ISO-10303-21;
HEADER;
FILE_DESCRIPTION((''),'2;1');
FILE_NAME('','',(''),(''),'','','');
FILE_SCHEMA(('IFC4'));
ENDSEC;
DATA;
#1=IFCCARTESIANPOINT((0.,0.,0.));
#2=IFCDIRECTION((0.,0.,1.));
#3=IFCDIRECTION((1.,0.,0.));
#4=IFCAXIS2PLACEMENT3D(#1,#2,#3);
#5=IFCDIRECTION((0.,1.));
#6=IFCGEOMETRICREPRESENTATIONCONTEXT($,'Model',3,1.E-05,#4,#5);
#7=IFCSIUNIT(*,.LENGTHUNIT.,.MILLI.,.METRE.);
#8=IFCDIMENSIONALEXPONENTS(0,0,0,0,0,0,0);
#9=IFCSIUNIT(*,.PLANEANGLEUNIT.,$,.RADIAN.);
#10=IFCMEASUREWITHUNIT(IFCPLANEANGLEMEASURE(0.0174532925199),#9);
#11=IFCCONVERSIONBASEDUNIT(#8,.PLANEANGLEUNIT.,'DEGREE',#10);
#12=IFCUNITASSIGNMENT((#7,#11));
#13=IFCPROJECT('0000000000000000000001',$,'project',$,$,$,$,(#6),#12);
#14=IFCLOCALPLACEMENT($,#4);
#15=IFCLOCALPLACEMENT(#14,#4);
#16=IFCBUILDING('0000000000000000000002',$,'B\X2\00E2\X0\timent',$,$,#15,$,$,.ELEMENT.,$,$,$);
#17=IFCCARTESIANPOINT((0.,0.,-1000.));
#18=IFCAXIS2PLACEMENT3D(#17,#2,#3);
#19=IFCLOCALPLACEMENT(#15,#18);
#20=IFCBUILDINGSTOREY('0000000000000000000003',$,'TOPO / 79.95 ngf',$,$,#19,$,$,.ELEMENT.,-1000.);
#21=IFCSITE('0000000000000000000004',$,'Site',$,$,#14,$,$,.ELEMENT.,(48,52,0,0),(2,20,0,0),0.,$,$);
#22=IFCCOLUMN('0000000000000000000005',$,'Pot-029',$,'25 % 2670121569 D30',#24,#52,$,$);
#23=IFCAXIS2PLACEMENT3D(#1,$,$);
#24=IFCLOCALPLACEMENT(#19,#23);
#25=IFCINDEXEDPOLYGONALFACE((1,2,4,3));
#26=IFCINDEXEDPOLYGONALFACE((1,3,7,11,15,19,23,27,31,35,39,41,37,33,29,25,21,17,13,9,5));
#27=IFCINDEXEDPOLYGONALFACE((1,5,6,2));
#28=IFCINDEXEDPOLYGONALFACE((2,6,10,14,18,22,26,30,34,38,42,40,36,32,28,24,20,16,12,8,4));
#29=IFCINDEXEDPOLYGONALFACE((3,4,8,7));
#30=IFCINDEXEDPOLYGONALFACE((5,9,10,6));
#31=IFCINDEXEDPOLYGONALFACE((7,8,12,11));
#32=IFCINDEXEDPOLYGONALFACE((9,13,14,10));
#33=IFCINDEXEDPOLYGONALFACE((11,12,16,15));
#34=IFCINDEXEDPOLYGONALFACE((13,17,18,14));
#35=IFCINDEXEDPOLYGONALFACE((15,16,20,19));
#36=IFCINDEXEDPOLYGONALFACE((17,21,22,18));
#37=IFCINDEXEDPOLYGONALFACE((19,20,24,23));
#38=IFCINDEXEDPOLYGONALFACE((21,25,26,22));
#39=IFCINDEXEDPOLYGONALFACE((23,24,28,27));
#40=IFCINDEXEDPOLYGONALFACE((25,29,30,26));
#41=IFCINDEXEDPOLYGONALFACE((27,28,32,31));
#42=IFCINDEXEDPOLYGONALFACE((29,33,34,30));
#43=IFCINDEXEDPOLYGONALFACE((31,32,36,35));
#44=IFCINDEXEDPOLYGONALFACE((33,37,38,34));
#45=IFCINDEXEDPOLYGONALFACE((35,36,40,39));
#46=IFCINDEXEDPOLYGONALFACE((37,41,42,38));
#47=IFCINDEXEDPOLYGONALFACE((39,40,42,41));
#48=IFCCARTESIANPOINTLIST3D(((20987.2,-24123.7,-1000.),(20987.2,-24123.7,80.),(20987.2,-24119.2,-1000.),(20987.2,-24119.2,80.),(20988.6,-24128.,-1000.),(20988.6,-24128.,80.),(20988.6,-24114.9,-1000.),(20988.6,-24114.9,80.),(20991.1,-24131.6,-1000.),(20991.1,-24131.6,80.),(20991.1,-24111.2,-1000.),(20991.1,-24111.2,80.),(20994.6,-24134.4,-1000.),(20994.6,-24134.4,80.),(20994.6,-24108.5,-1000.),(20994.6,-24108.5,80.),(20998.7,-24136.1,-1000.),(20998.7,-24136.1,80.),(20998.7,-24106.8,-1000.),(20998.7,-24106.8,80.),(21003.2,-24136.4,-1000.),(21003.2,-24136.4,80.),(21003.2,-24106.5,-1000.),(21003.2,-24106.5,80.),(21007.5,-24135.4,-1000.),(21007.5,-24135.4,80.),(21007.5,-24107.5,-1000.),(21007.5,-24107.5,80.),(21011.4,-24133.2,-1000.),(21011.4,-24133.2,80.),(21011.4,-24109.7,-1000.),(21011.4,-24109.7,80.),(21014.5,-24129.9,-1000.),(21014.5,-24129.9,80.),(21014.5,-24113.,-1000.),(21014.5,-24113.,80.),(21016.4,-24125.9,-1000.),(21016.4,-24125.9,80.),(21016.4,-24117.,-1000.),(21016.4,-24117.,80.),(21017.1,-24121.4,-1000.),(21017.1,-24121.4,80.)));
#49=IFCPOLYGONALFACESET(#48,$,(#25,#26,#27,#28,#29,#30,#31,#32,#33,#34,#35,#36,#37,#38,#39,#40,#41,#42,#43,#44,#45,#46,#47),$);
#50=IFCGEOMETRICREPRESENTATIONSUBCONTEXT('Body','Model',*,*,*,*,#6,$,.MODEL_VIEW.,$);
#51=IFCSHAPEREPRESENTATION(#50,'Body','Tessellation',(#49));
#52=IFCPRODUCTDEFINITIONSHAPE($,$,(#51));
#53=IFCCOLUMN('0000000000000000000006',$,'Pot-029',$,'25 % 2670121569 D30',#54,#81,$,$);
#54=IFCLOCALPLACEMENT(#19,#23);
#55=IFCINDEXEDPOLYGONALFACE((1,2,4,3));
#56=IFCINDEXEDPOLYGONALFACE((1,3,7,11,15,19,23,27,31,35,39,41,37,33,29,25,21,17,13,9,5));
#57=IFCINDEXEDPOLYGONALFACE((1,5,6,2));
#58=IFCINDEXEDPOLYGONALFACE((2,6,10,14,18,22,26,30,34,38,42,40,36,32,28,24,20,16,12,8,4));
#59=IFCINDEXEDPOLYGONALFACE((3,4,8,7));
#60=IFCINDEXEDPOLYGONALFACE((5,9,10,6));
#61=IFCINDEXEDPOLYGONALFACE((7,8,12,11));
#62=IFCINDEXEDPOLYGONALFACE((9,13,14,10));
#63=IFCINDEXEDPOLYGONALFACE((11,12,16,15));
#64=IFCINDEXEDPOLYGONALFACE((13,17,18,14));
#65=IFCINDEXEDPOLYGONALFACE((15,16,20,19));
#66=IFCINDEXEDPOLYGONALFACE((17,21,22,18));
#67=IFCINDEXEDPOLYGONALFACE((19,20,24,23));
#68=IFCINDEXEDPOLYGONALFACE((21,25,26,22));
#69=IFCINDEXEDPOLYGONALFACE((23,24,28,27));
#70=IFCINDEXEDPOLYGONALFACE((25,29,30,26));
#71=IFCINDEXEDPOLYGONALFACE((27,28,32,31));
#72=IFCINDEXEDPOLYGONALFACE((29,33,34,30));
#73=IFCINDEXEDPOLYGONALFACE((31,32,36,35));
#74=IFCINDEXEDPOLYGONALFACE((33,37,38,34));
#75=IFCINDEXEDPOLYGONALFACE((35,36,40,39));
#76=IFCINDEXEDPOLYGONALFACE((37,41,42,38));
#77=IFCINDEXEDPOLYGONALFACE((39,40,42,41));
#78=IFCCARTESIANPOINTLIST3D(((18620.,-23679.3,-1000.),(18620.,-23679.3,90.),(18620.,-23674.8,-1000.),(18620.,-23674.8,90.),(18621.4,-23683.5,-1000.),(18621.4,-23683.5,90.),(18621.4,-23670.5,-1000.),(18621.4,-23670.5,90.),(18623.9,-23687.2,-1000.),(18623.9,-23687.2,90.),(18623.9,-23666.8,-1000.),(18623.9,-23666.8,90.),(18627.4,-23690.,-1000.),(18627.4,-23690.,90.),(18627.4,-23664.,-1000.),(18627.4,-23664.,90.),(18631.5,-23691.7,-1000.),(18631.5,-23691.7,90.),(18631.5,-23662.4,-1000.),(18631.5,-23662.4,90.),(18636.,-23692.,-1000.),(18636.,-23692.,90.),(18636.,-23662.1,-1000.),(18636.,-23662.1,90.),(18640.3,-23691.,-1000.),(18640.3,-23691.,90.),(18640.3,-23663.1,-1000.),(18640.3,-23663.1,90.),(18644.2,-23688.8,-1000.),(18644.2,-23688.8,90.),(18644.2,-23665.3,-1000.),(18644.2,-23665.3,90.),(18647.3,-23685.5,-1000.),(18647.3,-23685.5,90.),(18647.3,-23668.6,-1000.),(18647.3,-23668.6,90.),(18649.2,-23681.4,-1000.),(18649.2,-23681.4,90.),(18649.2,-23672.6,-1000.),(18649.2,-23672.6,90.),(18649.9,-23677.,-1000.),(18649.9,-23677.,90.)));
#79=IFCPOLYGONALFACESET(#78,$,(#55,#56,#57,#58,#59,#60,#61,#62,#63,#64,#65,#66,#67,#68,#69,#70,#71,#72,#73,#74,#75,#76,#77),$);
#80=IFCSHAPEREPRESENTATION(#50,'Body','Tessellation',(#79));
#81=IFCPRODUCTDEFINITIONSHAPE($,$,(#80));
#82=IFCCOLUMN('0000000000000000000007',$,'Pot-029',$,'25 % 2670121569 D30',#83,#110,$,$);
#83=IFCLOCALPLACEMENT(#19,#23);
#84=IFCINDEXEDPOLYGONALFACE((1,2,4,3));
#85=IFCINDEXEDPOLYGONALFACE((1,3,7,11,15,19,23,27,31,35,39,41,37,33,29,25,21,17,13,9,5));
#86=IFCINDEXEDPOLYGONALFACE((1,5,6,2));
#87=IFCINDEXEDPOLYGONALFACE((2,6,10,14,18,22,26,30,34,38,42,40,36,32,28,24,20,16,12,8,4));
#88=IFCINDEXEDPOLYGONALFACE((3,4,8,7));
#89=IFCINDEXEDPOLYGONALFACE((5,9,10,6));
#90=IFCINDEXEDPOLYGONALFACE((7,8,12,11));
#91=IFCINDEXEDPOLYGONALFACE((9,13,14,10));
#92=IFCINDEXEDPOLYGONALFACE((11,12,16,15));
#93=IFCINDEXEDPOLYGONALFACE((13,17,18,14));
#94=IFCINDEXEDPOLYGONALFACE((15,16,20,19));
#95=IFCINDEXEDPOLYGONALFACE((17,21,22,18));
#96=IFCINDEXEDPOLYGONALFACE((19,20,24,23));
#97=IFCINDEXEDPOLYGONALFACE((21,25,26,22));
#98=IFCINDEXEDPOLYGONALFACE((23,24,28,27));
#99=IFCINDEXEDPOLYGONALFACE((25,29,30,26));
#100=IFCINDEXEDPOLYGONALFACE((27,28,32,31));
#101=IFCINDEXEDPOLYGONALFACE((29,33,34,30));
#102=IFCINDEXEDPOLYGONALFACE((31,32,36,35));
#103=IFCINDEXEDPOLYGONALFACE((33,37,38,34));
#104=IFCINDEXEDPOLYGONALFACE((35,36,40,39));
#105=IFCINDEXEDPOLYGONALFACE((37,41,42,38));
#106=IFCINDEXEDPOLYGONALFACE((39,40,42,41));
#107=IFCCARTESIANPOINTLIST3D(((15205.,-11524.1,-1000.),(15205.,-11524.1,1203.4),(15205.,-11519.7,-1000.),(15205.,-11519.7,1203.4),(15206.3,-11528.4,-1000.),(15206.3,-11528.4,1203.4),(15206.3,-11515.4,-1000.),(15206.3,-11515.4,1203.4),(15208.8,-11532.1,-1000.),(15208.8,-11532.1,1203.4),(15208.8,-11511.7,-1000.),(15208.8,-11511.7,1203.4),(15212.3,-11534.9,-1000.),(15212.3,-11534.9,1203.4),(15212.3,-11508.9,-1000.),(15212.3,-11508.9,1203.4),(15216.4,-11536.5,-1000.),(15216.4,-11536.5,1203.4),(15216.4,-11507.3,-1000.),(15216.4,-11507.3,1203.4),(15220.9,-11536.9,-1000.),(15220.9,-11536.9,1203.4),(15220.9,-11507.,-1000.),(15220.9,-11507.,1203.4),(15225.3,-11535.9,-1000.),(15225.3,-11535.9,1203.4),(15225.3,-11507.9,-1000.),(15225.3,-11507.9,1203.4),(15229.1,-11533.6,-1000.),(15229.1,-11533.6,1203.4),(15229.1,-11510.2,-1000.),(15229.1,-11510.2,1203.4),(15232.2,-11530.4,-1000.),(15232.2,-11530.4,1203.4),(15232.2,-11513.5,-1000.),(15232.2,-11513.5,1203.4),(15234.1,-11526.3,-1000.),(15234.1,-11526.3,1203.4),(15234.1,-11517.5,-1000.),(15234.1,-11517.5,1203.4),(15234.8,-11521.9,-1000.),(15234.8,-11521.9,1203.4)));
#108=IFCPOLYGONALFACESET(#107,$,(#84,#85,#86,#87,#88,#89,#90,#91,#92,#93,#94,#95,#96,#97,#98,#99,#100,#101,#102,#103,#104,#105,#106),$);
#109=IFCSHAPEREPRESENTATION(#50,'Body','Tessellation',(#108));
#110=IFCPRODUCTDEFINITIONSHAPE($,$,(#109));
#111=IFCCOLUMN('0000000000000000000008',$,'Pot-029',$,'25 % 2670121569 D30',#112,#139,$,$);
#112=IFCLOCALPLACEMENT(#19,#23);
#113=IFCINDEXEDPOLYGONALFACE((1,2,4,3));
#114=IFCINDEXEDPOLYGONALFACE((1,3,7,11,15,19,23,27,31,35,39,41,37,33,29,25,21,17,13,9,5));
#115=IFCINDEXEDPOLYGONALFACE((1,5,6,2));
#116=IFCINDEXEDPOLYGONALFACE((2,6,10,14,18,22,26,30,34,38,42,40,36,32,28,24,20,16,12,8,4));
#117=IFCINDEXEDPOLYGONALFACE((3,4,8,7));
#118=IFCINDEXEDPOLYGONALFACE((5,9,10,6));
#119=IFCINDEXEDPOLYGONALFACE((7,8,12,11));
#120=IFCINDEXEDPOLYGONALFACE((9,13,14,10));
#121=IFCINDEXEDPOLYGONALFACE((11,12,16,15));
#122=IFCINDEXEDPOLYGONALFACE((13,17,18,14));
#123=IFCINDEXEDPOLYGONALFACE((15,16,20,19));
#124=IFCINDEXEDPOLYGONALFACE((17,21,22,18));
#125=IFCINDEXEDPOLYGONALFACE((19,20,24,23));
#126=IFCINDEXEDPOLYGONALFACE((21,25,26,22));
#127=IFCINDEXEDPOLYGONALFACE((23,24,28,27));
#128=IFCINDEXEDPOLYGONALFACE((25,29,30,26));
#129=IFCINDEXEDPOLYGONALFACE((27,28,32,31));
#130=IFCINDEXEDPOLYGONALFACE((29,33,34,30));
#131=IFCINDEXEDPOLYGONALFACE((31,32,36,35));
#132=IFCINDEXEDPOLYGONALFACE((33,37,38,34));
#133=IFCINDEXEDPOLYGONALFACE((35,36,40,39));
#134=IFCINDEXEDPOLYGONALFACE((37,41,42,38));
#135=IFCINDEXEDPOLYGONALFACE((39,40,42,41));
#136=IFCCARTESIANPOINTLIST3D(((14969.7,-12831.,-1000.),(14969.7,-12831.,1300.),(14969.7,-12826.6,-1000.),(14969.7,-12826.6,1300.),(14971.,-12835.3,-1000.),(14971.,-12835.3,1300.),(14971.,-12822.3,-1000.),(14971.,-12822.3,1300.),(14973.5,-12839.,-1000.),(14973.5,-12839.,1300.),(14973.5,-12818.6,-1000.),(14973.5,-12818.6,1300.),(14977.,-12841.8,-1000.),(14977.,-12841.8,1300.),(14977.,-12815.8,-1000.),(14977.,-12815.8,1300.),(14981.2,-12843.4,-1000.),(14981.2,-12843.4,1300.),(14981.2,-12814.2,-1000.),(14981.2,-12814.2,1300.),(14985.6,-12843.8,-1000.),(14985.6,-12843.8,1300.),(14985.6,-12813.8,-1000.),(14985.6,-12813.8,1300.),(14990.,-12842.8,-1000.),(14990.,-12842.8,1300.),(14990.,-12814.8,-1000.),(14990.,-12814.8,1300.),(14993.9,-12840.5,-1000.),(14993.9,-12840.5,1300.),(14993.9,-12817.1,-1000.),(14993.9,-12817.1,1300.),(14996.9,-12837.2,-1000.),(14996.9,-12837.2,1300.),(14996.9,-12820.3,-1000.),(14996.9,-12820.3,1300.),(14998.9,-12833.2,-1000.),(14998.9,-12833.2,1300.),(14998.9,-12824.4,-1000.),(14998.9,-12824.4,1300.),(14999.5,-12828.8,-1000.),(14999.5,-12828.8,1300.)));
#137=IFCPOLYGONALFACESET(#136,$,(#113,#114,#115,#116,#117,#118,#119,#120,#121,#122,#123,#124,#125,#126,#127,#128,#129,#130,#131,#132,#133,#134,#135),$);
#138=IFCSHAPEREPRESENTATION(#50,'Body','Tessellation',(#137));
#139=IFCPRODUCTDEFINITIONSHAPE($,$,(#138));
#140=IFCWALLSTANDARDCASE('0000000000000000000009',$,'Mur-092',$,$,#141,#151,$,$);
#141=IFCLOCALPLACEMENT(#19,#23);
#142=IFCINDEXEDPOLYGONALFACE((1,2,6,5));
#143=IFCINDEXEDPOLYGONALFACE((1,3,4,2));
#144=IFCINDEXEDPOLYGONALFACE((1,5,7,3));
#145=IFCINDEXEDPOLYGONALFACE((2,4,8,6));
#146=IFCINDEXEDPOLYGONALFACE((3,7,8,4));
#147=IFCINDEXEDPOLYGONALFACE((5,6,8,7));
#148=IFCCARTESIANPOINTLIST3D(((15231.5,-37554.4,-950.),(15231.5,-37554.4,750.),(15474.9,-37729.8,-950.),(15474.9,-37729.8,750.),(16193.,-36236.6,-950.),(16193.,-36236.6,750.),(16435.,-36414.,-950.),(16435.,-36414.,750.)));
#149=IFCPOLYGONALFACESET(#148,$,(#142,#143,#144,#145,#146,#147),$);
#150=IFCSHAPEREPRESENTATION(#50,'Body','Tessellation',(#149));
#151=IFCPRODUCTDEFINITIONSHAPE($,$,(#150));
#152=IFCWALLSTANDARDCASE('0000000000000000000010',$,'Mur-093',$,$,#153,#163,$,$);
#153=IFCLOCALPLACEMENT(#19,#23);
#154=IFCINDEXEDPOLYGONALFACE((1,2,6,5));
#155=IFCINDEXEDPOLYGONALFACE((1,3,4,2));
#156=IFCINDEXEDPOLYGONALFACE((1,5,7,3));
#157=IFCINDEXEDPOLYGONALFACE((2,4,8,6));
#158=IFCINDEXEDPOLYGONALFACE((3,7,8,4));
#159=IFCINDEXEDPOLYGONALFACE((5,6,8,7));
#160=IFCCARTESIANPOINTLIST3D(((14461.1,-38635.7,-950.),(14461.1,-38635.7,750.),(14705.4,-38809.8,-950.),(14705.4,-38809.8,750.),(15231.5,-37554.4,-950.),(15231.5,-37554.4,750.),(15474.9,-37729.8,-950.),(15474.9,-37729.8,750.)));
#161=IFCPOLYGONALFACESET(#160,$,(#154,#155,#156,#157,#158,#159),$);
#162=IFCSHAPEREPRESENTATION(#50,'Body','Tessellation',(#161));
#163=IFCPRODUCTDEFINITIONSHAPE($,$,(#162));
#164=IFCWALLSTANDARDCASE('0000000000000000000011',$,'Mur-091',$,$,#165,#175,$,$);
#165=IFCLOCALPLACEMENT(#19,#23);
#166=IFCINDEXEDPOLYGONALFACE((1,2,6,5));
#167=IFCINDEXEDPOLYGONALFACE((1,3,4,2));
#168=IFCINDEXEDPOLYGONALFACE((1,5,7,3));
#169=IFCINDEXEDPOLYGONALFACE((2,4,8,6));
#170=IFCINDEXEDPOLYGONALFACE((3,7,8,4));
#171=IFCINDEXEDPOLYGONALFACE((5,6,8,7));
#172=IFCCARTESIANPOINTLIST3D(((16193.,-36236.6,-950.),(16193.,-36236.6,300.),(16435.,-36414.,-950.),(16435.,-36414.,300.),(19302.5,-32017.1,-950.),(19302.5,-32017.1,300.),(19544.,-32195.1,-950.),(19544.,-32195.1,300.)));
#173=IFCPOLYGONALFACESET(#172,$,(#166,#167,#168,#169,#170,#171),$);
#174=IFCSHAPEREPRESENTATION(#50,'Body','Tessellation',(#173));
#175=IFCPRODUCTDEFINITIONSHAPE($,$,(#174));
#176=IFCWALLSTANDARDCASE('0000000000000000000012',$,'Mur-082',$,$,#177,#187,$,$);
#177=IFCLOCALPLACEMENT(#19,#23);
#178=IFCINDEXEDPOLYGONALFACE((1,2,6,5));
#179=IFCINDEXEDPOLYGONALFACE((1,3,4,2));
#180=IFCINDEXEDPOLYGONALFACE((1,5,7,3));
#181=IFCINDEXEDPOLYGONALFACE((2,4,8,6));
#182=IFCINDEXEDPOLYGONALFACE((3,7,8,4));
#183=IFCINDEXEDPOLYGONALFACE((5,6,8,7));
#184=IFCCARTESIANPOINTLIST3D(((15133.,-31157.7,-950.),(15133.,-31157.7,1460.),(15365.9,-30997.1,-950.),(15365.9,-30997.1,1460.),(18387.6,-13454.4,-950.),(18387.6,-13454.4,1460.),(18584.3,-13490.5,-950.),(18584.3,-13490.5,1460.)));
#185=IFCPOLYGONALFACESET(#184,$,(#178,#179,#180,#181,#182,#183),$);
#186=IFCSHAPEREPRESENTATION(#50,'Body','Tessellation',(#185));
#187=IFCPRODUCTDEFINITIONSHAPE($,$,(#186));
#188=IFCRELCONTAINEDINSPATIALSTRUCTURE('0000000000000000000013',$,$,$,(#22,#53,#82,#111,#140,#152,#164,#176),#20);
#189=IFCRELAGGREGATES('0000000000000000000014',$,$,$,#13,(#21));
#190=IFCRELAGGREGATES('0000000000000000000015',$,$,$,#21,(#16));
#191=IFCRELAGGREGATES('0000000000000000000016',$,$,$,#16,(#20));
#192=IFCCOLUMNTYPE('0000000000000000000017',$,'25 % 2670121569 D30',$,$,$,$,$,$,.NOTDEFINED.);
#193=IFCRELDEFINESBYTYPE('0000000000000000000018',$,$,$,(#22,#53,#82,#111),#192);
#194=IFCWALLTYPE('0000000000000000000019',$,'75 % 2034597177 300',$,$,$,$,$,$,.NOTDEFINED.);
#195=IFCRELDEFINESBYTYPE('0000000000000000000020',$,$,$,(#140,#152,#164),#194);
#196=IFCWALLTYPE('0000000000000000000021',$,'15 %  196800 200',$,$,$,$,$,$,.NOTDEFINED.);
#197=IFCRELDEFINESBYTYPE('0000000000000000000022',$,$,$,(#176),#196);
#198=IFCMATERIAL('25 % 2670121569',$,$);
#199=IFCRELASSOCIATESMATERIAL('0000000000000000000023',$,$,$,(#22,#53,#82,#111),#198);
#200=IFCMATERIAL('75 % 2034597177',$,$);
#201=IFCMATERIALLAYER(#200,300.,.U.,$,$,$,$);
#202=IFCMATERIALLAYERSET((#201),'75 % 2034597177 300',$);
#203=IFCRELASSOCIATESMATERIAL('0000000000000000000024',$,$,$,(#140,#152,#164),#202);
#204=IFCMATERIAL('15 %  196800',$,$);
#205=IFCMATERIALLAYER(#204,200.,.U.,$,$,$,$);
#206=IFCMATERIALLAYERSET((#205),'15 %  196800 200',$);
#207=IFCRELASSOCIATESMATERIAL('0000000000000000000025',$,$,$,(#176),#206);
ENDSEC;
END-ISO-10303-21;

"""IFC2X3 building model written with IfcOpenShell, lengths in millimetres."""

from ifc_helpers import new_model, entity, si_unit, converted_unit, direction, frame, origin_with_axes, origin_2d_with_axis, place, context, subcontext, project, spatial, polyline, circle, outline, extrude, material, layer, layer_set, layer_usage, type_object, element, save


model = new_model("IFC2X3")

# Units and contexts
model_context = context("Model", 3, precision=1e-05, world=origin_with_axes(), true_north=direction((0.0, 1.0)))
body_context = subcontext(model_context, "Body", "Model", "MODEL_VIEW")
ifc_project = project(units=[si_unit("LENGTHUNIT", "METRE", prefix="MILLI"), converted_unit("PLANEANGLEUNIT", "DEGREE", entity("IfcPlaneAngleMeasure", 0.0174532925199), si_unit("PLANEANGLEUNIT", "RADIAN"), dimensions=[0, 0, 0, 0, 0, 0, 0])], contexts=[model_context])

# Site, building, storey
site_placement = place(None, origin_with_axes())
site = spatial("IfcSite", under=ifc_project, at=site_placement, Name="Site", CompositionType="ELEMENT", RefLatitude=(48, 52, 0, 0), RefLongitude=(2, 20, 0, 0), RefElevation=0.0)
building_placement = place(site_placement, origin_with_axes())
building = spatial("IfcBuilding", under=site, at=building_placement, Name="Bâtiment", CompositionType="ELEMENT")
storey_placement = place(building_placement, frame((0.0, 0.0, -1000.0), z_axis=(0.0, 0.0, 1.0), x_axis=(1.0, 0.0, 0.0)))
storey = spatial("IfcBuildingStorey", under=building, at=storey_placement, Name="TOPO / 79.95 ngf", CompositionType="ELEMENT", Elevation=-1000.0)

# Columns
ifc_material_1 = material(Name="25 % 2670121569")
column_type = type_object("IfcColumnType", Name="25 % 2670121569 D30", PredefinedType="NOTDEFINED")
column_1_placement = place(storey_placement, frame((21002.1, -24121.4, -1000.0), z_axis=(0.0, 0.0, 1.0), x_axis=(1.0, 0.0, 0.0)))
element("IfcColumn", 1, at=column_1_placement, inside=storey, type_object=column_type, material=ifc_material_1, Name="Pot-029", ObjectType="25 % 2670121569 D30", context=body_context, shape_type="SweptSolid", body=[
    extrude(circle(Radius=15.0, at=origin_2d_with_axis()), origin_with_axes(), (0.0, 0.0, 1.0), 1080.0),
])
column_2_placement = place(storey_placement, frame((18634.9, -23677.0, -1000.0), z_axis=(0.0, 0.0, 1.0), x_axis=(1.0, 0.0, 0.0)))
element("IfcColumn", 2, at=column_2_placement, inside=storey, type_object=column_type, material=ifc_material_1, Name="Pot-029", ObjectType="25 % 2670121569 D30", context=body_context, shape_type="SweptSolid", body=[
    extrude(circle(Radius=15.0, at=origin_2d_with_axis()), origin_with_axes(), (0.0, 0.0, 1.0), 1090.0),
])
column_3_placement = place(storey_placement, frame((15219.8, -11521.9, -1000.0), z_axis=(0.0, 0.0, 1.0), x_axis=(1.0, 0.0, 0.0)))
element("IfcColumn", 3, at=column_3_placement, inside=storey, type_object=column_type, material=ifc_material_1, Name="Pot-029", ObjectType="25 % 2670121569 D30", context=body_context, shape_type="SweptSolid", body=[
    extrude(circle(Radius=15.0, at=origin_2d_with_axis()), origin_with_axes(), (0.0, 0.0, 1.0), 2203.4),
])
column_4_placement = place(storey_placement, frame((14984.5, -12828.8, -1000.0), z_axis=(0.0, 0.0, 1.0), x_axis=(1.0, 0.0, 0.0)))
element("IfcColumn", 4, at=column_4_placement, inside=storey, type_object=column_type, material=ifc_material_1, Name="Pot-029", ObjectType="25 % 2670121569 D30", context=body_context, shape_type="SweptSolid", body=[
    extrude(circle(Radius=15.0, at=origin_2d_with_axis()), origin_with_axes(), (0.0, 0.0, 1.0), 2300.0),
])

# Walls
ifc_material_2 = material(Name="75 % 2034597177")
ifc_layer_1 = layer(ifc_material_2, 300.0, ventilated="UNKNOWN")
ifc_layer_set_1 = layer_set([ifc_layer_1], Name="75 % 2034597177 300")
ifc_layer_usage_1 = layer_usage(ifc_layer_set_1, "AXIS2", "NEGATIVE", 300.0)
wall_type_1 = type_object("IfcWallType", Name="75 % 2034597177 300", PredefinedType="NOTDEFINED")
wall_1_placement = place(storey_placement, frame((16193.0, -36236.6, -950.0), z_axis=(0.0, 0.0, 1.0), x_axis=(-0.589442, -0.807811, 0.0)))
element("IfcWallStandardCase", 5, at=wall_1_placement, inside=storey, type_object=wall_type_1, material=ifc_layer_usage_1, Name="Mur-092", context=body_context, shape_type="SweptSolid", body=[
    extrude(outline(polyline([(0.0, 0.0), (1631.2, 0.0), (1629.5, 300.0), (0.7, 300.0), (0.0, 0.0)])), origin_with_axes(), (0.0, 0.0, 1.0), 1700.0),
])
ifc_layer_usage_2 = layer_usage(ifc_layer_set_1, "AXIS2", "NEGATIVE", 300.0)
wall_2_placement = place(storey_placement, frame((15231.5, -37554.4, -950.0), z_axis=(0.0, 0.0, 1.0), x_axis=(-0.580268, -0.814426, 0.0)))
element("IfcWallStandardCase", 6, at=wall_2_placement, inside=storey, type_object=wall_type_1, material=ifc_layer_usage_2, Name="Mur-093", context=body_context, shape_type="SweptSolid", body=[
    extrude(outline(polyline([(0.0, 0.0), (1327.7, 0.0), (1327.7, 300.0), (1.7, 300.0), (0.0, 0.0)])), origin_with_axes(), (0.0, 0.0, 1.0), 1700.0),
])
ifc_layer_usage_3 = layer_usage(ifc_layer_set_1, "AXIS2", "NEGATIVE", 300.0)
wall_3_placement = place(storey_placement, frame((19302.5, -32017.1, -950.0), z_axis=(0.0, 0.0, 1.0), x_axis=(-0.593247, -0.805021, 0.0)))
element("IfcWallStandardCase", 7, at=wall_3_placement, inside=storey, type_object=wall_type_1, material=ifc_layer_usage_3, Name="Mur-091", context=body_context, shape_type="SweptSolid", body=[
    extrude(outline(polyline([(0.0, 0.0), (5241.5, 0.0), (5240.8, 300.0), (0.0, 300.0), (0.0, 0.0)])), origin_with_axes(), (0.0, 0.0, 1.0), 1250.0),
])
ifc_material_3 = material(Name="15 %  196800")
ifc_layer_2 = layer(ifc_material_3, 200.0, ventilated="UNKNOWN")
ifc_layer_set_2 = layer_set([ifc_layer_2], Name="15 %  196800 200")
wall_type_2 = type_object("IfcWallType", Name="15 %  196800 200", PredefinedType="NOTDEFINED")
ifc_layer_usage_4 = layer_usage(ifc_layer_set_2, "AXIS2", "POSITIVE", 0.0)
wall_4_placement = place(storey_placement, frame((18387.6, -13454.4, -950.0), z_axis=(0.0, 0.0, 1.0), x_axis=(-0.180809, -0.983518, 0.0)))
element("IfcWallStandardCase", 8, at=wall_4_placement, inside=storey, type_object=wall_type_2, material=ifc_layer_usage_4, Name="Mur-082", context=body_context, shape_type="SweptSolid", body=[
    extrude(outline(polyline([(0.0, 0.0), (18000.0, 0.0), (17800.0, 200.0), (0.0, 200.0), (0.0, 0.0)])), origin_with_axes(), (0.0, 0.0, 1.0), 2410.0),
])

save(model, "model.ifc")
